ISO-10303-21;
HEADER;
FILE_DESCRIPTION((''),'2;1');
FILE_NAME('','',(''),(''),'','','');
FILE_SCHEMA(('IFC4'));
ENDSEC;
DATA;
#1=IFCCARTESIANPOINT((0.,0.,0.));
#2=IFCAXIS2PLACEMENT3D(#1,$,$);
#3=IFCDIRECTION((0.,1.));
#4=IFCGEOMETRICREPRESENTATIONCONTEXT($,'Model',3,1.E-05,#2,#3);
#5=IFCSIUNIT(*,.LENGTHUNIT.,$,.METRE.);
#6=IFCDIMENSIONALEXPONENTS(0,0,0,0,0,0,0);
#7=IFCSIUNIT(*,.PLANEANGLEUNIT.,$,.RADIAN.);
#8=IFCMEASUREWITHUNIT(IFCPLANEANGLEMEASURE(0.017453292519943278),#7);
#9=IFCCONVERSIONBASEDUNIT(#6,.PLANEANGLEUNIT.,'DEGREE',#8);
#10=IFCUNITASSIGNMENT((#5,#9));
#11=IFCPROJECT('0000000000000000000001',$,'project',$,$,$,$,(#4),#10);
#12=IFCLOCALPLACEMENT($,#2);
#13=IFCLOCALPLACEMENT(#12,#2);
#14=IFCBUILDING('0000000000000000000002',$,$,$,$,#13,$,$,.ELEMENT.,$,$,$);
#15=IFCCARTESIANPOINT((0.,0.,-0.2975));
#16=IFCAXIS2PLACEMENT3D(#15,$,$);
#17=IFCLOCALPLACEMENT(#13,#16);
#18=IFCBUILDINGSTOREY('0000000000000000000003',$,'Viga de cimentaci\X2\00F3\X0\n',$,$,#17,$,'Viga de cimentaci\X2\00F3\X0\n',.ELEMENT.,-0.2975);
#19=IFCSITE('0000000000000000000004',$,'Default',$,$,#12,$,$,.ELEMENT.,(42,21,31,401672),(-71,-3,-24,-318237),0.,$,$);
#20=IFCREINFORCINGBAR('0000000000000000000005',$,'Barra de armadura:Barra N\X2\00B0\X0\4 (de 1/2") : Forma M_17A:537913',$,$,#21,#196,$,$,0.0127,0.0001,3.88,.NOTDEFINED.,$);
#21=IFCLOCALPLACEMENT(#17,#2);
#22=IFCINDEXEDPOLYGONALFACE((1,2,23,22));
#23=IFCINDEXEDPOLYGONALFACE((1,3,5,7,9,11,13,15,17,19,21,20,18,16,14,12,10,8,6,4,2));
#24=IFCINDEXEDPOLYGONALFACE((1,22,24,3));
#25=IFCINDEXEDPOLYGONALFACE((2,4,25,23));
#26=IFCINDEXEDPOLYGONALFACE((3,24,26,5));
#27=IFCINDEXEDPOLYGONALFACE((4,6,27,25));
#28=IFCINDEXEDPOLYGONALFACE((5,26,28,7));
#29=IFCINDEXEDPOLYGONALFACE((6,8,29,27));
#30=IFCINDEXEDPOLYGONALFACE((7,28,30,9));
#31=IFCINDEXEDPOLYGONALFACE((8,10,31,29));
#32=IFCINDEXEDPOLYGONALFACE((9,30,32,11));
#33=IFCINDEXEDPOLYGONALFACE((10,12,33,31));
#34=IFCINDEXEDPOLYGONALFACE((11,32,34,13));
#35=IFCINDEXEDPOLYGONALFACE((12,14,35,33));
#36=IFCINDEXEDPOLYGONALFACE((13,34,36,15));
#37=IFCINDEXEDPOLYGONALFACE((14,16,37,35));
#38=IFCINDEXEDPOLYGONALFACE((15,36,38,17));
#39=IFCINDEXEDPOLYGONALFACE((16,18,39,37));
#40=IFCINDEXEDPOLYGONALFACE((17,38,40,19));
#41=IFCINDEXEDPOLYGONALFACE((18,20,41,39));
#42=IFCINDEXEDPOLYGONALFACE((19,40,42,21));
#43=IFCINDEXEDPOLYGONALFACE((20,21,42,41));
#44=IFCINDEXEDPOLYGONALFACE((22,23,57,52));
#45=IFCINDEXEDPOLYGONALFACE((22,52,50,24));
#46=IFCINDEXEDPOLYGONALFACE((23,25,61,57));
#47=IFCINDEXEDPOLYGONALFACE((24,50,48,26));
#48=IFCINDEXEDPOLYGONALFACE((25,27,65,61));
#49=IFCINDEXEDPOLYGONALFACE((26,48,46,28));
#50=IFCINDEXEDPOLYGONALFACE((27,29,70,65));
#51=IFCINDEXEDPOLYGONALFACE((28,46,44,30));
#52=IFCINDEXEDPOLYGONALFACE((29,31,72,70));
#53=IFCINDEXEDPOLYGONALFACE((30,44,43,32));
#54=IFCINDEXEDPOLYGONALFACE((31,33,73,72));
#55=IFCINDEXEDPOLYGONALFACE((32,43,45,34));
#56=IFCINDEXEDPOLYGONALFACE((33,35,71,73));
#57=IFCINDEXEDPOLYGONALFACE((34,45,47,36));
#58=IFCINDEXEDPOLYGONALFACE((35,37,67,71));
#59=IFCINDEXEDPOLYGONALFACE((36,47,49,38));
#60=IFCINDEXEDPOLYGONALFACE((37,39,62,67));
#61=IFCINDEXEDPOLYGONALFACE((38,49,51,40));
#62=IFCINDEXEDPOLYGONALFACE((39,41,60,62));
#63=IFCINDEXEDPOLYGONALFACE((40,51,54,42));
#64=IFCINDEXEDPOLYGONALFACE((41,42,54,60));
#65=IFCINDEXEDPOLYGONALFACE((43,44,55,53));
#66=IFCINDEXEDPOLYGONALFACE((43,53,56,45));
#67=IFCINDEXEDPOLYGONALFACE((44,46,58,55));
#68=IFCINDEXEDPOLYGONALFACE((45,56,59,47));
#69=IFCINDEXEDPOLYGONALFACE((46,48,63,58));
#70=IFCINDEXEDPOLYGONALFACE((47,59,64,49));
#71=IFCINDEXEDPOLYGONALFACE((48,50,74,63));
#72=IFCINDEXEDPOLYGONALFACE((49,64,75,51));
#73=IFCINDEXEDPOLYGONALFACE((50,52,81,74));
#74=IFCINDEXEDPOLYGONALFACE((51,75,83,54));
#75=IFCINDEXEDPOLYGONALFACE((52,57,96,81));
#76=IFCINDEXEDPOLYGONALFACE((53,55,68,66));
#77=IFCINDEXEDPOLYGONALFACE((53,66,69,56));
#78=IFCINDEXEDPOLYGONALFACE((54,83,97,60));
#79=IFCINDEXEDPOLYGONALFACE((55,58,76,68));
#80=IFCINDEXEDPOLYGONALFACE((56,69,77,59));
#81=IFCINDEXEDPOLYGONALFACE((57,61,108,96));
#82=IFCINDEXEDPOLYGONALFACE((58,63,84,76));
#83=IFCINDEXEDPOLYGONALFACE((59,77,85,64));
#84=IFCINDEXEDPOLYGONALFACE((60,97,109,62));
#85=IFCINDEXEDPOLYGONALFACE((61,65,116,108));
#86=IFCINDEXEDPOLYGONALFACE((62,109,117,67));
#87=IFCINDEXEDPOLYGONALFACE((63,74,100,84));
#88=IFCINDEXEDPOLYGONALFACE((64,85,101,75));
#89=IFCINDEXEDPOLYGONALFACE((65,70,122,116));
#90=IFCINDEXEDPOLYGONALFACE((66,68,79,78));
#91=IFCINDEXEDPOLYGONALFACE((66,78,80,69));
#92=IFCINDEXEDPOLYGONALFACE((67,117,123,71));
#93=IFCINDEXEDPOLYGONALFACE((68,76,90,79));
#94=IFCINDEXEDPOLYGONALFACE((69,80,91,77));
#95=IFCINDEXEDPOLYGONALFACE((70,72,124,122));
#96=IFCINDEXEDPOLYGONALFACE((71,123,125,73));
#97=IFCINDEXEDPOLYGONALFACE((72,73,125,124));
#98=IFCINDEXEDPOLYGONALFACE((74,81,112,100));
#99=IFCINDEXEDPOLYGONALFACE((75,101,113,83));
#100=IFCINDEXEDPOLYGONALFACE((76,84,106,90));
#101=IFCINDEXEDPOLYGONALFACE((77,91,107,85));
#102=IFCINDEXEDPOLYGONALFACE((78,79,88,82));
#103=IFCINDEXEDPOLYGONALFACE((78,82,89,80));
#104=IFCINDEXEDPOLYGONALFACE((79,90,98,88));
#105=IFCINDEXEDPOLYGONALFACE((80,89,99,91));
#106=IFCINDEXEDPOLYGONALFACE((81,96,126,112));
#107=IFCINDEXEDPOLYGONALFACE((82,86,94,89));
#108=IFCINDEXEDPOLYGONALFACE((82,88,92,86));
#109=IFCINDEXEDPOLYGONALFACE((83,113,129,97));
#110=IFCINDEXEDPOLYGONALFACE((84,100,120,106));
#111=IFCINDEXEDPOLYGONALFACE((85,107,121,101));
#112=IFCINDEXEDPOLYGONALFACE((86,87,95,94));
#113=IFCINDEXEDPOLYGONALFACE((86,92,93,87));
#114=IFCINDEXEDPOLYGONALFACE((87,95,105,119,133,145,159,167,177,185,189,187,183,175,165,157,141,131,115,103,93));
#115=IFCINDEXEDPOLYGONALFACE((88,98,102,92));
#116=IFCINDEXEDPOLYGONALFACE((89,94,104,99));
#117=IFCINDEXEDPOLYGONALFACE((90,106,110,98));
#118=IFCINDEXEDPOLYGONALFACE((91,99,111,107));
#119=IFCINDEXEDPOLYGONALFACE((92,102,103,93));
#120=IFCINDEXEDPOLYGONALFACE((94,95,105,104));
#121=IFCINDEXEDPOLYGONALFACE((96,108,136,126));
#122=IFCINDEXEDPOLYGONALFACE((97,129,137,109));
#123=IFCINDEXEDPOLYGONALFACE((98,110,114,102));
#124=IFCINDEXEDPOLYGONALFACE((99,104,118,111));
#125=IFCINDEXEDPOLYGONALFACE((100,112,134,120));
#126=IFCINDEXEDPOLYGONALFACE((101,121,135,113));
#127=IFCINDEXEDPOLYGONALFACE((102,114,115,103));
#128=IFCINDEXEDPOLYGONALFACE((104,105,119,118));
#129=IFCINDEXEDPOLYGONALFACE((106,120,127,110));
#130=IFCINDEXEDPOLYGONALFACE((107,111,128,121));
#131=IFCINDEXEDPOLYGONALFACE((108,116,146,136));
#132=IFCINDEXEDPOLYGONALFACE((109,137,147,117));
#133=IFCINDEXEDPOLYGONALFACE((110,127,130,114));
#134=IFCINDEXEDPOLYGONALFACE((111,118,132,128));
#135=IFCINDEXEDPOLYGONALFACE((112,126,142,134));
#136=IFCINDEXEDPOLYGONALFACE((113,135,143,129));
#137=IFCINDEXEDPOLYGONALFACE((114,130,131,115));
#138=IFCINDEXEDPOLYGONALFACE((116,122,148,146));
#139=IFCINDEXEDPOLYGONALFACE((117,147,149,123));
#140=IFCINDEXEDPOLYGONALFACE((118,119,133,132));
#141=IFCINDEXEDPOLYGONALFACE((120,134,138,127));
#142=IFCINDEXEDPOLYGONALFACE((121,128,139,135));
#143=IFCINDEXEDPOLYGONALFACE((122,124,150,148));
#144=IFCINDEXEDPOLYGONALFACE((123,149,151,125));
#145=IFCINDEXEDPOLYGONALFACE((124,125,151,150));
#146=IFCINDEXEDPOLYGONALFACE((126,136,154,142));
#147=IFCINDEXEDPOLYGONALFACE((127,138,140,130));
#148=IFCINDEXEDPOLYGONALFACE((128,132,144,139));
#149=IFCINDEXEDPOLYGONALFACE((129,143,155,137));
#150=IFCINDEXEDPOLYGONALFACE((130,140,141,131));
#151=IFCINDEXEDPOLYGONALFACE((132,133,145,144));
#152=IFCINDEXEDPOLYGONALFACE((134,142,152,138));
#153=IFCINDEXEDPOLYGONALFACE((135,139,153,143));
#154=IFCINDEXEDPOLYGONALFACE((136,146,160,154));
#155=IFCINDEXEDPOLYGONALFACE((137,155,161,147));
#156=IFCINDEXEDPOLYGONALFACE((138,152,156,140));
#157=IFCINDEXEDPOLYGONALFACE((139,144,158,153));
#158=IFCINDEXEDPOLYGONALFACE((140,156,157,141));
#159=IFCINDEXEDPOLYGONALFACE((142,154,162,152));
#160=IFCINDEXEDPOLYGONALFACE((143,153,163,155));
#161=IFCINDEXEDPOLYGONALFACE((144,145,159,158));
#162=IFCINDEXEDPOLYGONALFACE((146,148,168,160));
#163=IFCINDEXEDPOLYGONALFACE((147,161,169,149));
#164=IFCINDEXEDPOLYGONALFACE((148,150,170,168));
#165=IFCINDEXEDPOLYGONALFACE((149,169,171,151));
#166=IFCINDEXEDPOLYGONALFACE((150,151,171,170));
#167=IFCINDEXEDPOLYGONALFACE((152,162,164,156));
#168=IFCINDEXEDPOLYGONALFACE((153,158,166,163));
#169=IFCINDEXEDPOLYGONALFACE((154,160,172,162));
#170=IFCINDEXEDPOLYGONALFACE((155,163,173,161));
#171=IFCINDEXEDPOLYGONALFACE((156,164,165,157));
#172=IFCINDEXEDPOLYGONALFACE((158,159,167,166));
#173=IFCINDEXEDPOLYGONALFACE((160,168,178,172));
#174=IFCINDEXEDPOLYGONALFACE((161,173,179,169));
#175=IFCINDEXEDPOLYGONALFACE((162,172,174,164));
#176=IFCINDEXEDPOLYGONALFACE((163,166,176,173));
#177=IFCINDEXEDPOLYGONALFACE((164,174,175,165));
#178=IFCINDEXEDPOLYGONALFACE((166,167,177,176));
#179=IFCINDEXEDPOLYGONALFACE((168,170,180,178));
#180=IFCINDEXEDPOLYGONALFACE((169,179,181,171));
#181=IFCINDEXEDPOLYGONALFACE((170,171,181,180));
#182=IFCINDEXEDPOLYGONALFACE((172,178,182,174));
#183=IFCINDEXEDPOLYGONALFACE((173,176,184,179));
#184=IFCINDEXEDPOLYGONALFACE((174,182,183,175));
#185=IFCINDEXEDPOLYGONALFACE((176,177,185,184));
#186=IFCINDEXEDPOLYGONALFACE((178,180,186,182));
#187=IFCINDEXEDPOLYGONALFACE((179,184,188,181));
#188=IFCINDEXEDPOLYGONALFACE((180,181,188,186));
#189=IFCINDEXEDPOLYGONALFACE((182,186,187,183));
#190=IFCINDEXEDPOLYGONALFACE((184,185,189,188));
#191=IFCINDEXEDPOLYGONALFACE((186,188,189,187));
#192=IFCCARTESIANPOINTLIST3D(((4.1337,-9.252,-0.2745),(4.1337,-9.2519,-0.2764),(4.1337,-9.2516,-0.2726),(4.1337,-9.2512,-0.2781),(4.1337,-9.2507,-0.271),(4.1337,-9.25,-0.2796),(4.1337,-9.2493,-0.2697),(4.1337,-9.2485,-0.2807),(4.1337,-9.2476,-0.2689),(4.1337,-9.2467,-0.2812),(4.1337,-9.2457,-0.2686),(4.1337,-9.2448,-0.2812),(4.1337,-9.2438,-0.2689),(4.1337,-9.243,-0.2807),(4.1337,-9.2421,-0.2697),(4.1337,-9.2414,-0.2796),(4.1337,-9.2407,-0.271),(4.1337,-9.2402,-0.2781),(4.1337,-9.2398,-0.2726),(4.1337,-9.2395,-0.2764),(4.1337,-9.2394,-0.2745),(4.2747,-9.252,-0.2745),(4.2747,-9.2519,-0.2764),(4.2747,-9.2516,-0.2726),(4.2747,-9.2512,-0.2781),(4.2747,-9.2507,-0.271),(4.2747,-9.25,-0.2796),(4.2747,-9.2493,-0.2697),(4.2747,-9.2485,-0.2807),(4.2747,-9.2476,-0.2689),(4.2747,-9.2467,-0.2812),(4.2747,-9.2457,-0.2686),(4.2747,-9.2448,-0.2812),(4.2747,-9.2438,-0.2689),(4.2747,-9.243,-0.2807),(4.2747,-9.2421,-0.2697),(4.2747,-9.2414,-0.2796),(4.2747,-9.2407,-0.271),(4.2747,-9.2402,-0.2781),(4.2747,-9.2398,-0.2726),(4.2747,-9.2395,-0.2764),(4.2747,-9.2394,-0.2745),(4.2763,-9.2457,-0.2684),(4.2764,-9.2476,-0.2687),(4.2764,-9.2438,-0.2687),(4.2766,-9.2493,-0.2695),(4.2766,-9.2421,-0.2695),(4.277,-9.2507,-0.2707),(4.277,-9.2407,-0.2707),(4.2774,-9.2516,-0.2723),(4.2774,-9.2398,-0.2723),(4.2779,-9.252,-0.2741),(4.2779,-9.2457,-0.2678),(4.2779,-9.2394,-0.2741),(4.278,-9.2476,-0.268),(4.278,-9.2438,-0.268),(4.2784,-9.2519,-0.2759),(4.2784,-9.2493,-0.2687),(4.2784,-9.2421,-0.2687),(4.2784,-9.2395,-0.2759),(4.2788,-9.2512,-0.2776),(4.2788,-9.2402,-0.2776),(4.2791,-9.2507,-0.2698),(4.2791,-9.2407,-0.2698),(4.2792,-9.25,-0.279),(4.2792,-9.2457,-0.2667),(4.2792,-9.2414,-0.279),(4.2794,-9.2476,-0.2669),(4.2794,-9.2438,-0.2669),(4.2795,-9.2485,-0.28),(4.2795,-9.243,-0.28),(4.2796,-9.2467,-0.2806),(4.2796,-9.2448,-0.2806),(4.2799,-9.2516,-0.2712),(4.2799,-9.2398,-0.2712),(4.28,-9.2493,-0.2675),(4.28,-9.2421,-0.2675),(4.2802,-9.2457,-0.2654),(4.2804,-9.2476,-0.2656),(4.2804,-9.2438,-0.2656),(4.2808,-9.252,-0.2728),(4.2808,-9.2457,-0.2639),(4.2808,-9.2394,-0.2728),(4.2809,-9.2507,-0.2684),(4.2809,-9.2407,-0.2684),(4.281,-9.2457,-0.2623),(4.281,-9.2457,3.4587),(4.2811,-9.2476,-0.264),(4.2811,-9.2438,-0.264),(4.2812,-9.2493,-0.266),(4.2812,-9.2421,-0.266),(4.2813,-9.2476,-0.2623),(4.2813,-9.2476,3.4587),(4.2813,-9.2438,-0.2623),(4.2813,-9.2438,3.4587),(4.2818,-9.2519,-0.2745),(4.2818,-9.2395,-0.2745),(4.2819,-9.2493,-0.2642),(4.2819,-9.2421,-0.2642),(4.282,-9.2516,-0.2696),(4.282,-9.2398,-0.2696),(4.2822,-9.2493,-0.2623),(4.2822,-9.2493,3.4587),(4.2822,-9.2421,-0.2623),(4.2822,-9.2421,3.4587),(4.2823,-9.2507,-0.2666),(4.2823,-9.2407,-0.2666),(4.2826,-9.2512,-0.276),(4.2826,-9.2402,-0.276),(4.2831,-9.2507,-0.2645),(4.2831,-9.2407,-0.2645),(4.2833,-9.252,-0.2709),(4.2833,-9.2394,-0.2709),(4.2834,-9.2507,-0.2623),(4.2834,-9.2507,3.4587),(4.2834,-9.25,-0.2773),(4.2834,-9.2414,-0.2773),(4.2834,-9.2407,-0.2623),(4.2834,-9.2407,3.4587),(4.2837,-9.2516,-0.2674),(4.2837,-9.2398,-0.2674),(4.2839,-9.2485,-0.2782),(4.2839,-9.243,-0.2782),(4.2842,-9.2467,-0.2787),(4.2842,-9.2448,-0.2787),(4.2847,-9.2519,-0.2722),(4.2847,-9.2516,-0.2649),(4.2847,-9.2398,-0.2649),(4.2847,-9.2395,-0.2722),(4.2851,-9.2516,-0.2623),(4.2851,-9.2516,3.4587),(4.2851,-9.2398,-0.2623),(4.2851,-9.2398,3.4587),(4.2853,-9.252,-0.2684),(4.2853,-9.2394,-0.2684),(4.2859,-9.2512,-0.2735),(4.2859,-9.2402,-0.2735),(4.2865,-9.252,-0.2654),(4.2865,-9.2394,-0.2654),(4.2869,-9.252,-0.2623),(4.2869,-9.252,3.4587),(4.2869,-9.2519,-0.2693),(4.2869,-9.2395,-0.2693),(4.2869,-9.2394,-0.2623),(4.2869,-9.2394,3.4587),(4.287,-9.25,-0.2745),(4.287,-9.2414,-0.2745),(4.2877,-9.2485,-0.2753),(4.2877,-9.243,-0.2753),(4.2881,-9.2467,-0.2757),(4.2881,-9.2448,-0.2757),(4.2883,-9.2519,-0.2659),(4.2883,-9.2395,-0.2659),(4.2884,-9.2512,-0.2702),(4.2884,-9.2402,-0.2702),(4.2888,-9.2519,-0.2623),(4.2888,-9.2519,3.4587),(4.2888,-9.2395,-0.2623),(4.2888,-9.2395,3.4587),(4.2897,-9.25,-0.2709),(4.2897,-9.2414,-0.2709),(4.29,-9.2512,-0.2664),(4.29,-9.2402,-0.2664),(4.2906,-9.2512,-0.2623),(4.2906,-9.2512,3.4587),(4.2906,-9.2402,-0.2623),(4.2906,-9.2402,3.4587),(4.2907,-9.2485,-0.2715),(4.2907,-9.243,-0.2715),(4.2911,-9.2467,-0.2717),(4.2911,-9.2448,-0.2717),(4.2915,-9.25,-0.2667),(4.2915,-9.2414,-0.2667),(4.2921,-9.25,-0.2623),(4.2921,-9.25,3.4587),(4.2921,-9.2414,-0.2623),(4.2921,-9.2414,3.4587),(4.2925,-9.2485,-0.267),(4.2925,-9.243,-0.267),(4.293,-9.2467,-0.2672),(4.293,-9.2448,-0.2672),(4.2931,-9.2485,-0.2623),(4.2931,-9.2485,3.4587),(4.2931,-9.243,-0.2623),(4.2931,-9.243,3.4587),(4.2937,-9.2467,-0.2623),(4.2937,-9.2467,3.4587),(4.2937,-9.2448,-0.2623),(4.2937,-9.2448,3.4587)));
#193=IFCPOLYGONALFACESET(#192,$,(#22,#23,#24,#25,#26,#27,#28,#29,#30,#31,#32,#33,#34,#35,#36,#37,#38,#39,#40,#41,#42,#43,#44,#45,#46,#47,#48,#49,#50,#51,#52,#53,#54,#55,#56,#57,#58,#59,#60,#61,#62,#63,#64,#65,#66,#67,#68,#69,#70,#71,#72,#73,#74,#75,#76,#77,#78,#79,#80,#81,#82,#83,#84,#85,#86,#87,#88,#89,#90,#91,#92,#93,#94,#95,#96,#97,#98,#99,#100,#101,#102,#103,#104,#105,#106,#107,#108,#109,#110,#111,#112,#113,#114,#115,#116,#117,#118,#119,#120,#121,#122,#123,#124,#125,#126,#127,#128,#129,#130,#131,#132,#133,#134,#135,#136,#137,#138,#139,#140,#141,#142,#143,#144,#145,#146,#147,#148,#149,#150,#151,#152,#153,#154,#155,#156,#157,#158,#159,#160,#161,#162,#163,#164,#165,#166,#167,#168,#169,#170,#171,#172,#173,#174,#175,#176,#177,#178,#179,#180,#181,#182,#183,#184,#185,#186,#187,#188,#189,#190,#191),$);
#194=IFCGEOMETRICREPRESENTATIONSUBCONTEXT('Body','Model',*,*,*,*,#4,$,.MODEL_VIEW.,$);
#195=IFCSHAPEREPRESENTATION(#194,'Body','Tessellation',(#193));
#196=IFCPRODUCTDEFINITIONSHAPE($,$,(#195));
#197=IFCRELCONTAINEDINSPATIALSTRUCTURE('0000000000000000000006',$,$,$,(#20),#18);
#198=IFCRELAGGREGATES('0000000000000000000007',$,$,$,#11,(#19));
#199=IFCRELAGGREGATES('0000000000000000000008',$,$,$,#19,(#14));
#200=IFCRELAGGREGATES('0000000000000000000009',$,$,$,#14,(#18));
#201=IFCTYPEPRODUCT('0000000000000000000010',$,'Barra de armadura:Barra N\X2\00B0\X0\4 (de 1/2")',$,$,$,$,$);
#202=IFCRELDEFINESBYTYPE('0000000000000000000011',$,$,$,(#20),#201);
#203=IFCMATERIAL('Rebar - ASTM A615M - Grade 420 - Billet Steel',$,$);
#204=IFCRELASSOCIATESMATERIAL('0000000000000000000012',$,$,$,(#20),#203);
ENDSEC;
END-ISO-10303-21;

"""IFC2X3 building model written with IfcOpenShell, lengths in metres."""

from ifc_helpers import new_model, entity, si_unit, converted_unit, direction, frame, origin, place, context, subcontext, project, spatial, material, type_object, element, save


model = new_model("IFC2X3")

# Units and contexts
model_context = context("Model", 3, precision=1e-05, world=origin(), true_north=direction((0.0, 1.0)))
body_context = subcontext(model_context, "Body", "Model", "MODEL_VIEW")
ifc_project = project(units=[si_unit("LENGTHUNIT", "METRE"), converted_unit("PLANEANGLEUNIT", "DEGREE", entity("IfcPlaneAngleMeasure", 0.017453292519943278), si_unit("PLANEANGLEUNIT", "RADIAN"), dimensions=[0, 0, 0, 0, 0, 0, 0])], contexts=[model_context])

# Site, building, storey
site_placement = place(None, origin())
site = spatial("IfcSite", under=ifc_project, at=site_placement, Name="Default", CompositionType="ELEMENT", RefLatitude=(42, 21, 31, 401672), RefLongitude=(-71, -3, -24, -318237), RefElevation=0.0)
building_placement = place(site_placement, origin())
building = spatial("IfcBuilding", under=site, at=building_placement, CompositionType="ELEMENT")
storey_placement = place(building_placement, frame((0.0, 0.0, -0.2975)))
storey = spatial("IfcBuildingStorey", under=building, at=storey_placement, Name="Viga de cimentación", LongName="Viga de cimentación", CompositionType="ELEMENT", Elevation=-0.2975)

# Reinforcing bar
ifc_material_1 = material(Name="Rebar - ASTM A615M - Grade 420 - Billet Steel")
type_product_1 = type_object("IfcTypeProduct", Name="Barra de armadura:Barra N°4 (de 1/2\")")
reinforcing_bar_1_placement = place(storey_placement, origin())
element("IfcReinforcingBar", 1, at=reinforcing_bar_1_placement, inside=storey, type_object=type_product_1, material=ifc_material_1, Name="Barra de armadura:Barra N°4 (de 1/2\") : Forma M_17A:537913", BarLength=3.88, BarRole="NOTDEFINED", CrossSectionArea=0.0001, NominalDiameter=0.0127, context=body_context, shape_type="AdvancedSweptSolid", body=[
    entity("IfcSweptDiskSolid", entity("IfcCompositeCurve", [entity("IfcCompositeCurveSegment", "CONTINUOUS", True, entity("IfcPolyline", [entity("IfcCartesianPoint", [4.2874, -9.2457, 3.4587]), entity("IfcCartesianPoint", [4.2874, -9.2457, -0.2623])])), entity("IfcCompositeCurveSegment", "CONTINUOUS", True, entity("IfcTrimmedCurve", entity("IfcCircle", entity("IfcAxis2Placement3D", entity("IfcCartesianPoint", [4.2747, -9.2457, -0.2623]), entity("IfcDirection", [0.0, 1.0, 0.0]), entity("IfcDirection", [0.0, 0.0, -1.0])), 0.0127), [entity("IfcParameterValue", 270.0)], [entity("IfcParameterValue", 360.0)], True, "PARAMETER")), entity("IfcCompositeCurveSegment", "CONTINUOUS", True, entity("IfcPolyline", [entity("IfcCartesianPoint", [4.2747, -9.2457, -0.275]), entity("IfcCartesianPoint", [4.1337, -9.2457, -0.275])]))], False), 0.0063, None, 0.0, 92.0),
])

save(model, "model.ifc")
